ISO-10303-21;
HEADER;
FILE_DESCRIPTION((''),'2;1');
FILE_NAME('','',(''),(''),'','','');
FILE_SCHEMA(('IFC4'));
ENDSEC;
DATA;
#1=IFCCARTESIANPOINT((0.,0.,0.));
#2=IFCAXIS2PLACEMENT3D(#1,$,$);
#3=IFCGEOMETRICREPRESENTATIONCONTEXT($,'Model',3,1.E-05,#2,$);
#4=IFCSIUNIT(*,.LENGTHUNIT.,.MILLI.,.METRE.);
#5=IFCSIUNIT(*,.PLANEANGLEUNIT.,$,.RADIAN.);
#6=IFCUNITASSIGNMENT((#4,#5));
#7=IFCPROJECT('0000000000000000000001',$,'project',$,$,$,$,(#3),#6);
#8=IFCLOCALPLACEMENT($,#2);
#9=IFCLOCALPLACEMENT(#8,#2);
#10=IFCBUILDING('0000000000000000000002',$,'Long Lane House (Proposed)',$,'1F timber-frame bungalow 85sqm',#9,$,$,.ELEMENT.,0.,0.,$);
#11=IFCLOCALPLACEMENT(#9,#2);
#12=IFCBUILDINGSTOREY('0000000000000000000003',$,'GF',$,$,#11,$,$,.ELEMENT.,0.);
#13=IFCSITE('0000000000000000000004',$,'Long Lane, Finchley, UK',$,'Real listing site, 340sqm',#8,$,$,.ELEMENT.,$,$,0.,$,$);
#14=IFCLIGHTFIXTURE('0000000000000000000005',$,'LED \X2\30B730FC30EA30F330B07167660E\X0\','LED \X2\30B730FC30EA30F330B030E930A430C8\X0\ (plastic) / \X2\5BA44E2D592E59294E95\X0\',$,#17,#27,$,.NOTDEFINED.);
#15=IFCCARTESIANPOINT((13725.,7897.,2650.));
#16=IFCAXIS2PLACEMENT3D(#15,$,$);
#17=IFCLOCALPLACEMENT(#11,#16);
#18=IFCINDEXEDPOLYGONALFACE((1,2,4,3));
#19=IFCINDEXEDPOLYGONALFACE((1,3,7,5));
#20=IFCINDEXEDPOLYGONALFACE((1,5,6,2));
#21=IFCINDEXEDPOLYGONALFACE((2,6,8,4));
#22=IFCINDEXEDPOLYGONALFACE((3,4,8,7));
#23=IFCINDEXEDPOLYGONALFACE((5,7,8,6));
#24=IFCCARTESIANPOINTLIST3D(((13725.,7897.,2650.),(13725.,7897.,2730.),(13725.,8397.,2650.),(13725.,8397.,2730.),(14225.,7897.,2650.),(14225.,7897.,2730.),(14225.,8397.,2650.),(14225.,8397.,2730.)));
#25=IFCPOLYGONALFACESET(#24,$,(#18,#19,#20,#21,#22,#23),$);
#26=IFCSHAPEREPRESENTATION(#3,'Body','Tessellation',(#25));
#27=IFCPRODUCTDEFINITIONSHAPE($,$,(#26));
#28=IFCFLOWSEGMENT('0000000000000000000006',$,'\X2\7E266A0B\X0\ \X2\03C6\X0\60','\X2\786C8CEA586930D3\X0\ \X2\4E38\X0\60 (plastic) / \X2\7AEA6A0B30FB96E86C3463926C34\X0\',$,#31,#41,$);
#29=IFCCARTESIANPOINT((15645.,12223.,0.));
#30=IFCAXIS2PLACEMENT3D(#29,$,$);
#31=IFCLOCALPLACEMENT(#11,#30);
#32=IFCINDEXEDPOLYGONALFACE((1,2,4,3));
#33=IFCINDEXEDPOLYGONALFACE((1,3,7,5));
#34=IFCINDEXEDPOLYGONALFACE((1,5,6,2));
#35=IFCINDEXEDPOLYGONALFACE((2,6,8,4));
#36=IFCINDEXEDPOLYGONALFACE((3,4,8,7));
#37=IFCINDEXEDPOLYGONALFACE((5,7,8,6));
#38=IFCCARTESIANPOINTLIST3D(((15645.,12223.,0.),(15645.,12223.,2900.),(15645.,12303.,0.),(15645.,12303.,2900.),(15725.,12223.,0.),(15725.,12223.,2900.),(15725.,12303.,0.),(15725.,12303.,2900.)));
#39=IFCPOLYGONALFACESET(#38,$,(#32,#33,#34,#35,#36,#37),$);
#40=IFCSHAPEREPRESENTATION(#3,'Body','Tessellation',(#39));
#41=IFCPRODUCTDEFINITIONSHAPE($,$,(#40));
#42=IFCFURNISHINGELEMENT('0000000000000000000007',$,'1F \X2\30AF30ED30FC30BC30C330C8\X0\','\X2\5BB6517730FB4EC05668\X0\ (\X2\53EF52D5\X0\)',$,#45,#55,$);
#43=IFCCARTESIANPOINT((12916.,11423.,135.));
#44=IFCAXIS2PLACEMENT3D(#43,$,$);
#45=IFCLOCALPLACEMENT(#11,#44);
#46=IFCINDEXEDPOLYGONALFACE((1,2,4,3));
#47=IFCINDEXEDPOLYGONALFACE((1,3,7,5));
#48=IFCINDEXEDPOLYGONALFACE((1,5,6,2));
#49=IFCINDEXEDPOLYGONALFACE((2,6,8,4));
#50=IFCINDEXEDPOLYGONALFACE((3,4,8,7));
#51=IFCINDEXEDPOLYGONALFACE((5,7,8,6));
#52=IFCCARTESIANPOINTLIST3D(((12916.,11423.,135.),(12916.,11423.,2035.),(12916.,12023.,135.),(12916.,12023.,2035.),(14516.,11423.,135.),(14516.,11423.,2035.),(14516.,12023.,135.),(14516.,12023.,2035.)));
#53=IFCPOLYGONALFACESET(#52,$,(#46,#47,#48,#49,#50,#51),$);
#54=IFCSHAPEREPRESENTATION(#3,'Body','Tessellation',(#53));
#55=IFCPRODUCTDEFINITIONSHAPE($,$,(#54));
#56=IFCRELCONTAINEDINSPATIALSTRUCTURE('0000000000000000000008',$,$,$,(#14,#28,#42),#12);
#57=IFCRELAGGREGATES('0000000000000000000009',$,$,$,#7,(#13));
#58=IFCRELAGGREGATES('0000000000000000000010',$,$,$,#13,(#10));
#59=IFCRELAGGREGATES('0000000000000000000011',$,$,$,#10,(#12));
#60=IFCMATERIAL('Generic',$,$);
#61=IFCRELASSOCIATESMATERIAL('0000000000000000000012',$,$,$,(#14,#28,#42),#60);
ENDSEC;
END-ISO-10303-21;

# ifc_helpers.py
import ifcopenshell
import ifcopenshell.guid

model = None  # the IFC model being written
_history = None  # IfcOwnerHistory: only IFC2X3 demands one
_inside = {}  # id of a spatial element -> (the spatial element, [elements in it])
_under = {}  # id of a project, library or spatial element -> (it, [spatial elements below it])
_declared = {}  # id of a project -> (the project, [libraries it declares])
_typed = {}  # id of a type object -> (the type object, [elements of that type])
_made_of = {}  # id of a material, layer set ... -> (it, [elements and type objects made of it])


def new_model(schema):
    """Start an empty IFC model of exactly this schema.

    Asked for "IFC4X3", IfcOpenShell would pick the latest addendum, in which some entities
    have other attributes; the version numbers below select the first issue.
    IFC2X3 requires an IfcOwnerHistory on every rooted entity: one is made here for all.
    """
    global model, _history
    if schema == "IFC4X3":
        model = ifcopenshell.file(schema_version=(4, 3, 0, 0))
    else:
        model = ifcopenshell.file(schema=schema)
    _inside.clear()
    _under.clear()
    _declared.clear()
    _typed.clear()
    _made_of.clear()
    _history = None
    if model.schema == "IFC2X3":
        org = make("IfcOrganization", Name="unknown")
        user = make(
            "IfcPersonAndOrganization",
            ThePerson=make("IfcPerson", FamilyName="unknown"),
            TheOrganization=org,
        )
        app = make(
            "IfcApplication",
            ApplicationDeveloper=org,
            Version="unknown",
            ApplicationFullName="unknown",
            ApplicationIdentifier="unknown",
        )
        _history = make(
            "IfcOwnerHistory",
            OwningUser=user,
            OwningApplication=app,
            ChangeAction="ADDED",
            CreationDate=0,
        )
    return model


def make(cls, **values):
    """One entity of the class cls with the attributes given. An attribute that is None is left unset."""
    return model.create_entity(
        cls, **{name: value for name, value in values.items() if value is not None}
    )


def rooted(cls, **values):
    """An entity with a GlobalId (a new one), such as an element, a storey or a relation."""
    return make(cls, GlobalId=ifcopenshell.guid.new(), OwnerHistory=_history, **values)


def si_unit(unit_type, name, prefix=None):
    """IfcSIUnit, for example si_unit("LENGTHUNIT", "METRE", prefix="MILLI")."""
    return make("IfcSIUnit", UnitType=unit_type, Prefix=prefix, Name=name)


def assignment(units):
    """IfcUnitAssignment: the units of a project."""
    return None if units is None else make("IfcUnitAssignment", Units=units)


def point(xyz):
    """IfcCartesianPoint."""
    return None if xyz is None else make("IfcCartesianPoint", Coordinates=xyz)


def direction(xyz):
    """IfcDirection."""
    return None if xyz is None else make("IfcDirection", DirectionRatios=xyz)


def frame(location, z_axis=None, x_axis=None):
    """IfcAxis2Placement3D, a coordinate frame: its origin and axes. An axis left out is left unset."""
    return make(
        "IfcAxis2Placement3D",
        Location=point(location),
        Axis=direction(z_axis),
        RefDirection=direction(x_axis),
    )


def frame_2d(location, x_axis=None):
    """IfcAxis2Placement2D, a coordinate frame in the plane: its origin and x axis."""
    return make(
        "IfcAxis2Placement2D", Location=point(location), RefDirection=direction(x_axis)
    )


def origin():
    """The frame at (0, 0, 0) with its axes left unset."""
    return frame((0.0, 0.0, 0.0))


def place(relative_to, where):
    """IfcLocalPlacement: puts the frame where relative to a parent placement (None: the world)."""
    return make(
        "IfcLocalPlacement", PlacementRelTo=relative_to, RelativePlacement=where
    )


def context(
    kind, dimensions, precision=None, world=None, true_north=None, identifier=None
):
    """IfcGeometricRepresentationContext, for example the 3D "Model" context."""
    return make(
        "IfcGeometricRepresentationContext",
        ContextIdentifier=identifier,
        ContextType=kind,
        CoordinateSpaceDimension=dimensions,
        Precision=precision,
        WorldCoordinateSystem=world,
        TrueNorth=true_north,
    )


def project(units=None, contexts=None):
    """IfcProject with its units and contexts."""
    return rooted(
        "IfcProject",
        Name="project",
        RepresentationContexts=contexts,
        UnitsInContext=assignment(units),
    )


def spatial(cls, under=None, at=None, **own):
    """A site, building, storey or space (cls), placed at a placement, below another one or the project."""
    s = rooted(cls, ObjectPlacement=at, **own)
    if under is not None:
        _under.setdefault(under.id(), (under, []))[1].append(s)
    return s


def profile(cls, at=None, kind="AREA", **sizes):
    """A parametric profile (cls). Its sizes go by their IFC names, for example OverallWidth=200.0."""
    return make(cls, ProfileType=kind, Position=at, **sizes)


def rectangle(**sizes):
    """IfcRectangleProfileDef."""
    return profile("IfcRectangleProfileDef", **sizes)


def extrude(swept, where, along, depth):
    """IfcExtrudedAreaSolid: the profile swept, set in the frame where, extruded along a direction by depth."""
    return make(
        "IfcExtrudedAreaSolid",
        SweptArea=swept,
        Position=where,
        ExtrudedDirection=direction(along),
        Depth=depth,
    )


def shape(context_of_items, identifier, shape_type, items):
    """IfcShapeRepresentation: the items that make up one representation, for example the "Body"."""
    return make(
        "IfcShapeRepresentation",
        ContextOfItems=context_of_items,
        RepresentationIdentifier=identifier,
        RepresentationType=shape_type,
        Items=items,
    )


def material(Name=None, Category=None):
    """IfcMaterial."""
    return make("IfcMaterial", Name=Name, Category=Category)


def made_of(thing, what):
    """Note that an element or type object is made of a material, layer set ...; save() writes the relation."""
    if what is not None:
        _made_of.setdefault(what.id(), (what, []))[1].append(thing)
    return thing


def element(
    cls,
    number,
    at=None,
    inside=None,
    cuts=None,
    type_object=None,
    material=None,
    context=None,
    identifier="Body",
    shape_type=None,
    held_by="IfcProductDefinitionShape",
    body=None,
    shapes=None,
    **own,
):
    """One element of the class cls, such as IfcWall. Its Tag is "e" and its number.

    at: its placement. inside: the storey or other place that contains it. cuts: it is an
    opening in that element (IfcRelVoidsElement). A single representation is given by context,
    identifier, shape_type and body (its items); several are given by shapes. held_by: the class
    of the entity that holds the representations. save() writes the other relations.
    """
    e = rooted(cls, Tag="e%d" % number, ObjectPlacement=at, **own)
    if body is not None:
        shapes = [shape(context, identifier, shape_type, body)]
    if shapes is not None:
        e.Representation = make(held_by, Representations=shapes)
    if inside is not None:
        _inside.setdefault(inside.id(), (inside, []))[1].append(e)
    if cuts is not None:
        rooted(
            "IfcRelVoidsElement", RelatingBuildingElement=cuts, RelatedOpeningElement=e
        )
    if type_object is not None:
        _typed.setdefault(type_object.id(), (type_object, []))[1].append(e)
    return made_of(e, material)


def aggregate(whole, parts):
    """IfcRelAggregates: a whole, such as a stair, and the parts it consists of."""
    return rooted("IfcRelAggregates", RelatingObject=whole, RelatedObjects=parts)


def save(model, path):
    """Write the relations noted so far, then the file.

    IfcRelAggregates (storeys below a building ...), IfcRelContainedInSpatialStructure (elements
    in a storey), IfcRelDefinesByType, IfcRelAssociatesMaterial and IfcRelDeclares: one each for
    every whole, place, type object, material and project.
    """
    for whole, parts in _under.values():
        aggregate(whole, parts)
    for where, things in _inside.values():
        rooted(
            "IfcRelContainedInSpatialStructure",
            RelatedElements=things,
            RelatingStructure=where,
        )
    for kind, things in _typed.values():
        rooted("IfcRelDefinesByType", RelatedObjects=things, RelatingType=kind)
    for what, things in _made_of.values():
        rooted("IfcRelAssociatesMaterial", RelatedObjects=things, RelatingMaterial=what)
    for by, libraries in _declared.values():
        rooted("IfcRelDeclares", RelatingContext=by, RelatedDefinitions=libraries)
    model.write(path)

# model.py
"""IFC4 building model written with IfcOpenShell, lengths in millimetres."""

from ifc_helpers import new_model, si_unit, frame, frame_2d, origin, place, context, project, spatial, rectangle, extrude, material, element, save


model = new_model("IFC4")

# Units and contexts
model_context = context("Model", 3, precision=1e-05, world=origin())
ifc_project = project(units=[si_unit("LENGTHUNIT", "METRE", prefix="MILLI"), si_unit("PLANEANGLEUNIT", "RADIAN")], contexts=[model_context])

# Site, building, storey
site_placement = place(None, origin())
site = spatial("IfcSite", under=ifc_project, at=site_placement, Name="Long Lane, Finchley, UK", ObjectType="Real listing site, 340sqm", CompositionType="ELEMENT", RefElevation=0.0)
building_placement = place(site_placement, origin())
building = spatial("IfcBuilding", under=site, at=building_placement, Name="Long Lane House (Proposed)", ObjectType="1F timber-frame bungalow 85sqm", CompositionType="ELEMENT", ElevationOfRefHeight=0.0, ElevationOfTerrain=0.0)
storey_placement = place(building_placement, origin())
storey = spatial("IfcBuildingStorey", under=building, at=storey_placement, Name="GF", CompositionType="ELEMENT", Elevation=0.0)

# Shared definitions
ifc_material_1 = material(Name="Generic")

# Light fixture
light_fixture_1_placement = place(storey_placement, frame((13725.0, 7897.0, 2650.0)))
element("IfcLightFixture", 1, at=light_fixture_1_placement, inside=storey, material=ifc_material_1, Name="LED シーリング照明", Description="LED シーリングライト (plastic) / 室中央天井", PredefinedType="NOTDEFINED", context=model_context, shape_type="SweptSolid", body=[
    extrude(rectangle(XDim=500.0, YDim=500.0, at=frame_2d((250.0, 250.0))), frame((13725.0, 7897.0, 2650.0)), (0.0, 0.0, 1.0), 80.0),
])

# Flow segment
flow_segment_placement = place(storey_placement, frame((15645.0, 12223.0, 0.0)))
element("IfcFlowSegment", 2, at=flow_segment_placement, inside=storey, material=ifc_material_1, Name="縦樋 φ60", Description="硬質塩ビ 丸60 (plastic) / 竪樋・雨水排水", context=model_context, shape_type="SweptSolid", body=[
    extrude(rectangle(XDim=80.0, YDim=80.0, at=frame_2d((40.0, 40.0))), frame((15645.0, 12223.0, 0.0)), (0.0, 0.0, 1.0), 2900.0),
])

# Furnishing element
furnishing_placement = place(storey_placement, frame((12916.0, 11423.0, 135.0)))
element("IfcFurnishingElement", 3, at=furnishing_placement, inside=storey, material=ifc_material_1, Name="1F クローゼット", Description="家具・什器 (可動)", context=model_context, shape_type="SweptSolid", body=[
    extrude(rectangle(XDim=1600.0, YDim=600.0, at=frame_2d((800.0, 300.0))), frame((12916.0, 11423.0, 135.0)), (0.0, 0.0, 1.0), 1900.0),
])

save(model, "model.ifc")
